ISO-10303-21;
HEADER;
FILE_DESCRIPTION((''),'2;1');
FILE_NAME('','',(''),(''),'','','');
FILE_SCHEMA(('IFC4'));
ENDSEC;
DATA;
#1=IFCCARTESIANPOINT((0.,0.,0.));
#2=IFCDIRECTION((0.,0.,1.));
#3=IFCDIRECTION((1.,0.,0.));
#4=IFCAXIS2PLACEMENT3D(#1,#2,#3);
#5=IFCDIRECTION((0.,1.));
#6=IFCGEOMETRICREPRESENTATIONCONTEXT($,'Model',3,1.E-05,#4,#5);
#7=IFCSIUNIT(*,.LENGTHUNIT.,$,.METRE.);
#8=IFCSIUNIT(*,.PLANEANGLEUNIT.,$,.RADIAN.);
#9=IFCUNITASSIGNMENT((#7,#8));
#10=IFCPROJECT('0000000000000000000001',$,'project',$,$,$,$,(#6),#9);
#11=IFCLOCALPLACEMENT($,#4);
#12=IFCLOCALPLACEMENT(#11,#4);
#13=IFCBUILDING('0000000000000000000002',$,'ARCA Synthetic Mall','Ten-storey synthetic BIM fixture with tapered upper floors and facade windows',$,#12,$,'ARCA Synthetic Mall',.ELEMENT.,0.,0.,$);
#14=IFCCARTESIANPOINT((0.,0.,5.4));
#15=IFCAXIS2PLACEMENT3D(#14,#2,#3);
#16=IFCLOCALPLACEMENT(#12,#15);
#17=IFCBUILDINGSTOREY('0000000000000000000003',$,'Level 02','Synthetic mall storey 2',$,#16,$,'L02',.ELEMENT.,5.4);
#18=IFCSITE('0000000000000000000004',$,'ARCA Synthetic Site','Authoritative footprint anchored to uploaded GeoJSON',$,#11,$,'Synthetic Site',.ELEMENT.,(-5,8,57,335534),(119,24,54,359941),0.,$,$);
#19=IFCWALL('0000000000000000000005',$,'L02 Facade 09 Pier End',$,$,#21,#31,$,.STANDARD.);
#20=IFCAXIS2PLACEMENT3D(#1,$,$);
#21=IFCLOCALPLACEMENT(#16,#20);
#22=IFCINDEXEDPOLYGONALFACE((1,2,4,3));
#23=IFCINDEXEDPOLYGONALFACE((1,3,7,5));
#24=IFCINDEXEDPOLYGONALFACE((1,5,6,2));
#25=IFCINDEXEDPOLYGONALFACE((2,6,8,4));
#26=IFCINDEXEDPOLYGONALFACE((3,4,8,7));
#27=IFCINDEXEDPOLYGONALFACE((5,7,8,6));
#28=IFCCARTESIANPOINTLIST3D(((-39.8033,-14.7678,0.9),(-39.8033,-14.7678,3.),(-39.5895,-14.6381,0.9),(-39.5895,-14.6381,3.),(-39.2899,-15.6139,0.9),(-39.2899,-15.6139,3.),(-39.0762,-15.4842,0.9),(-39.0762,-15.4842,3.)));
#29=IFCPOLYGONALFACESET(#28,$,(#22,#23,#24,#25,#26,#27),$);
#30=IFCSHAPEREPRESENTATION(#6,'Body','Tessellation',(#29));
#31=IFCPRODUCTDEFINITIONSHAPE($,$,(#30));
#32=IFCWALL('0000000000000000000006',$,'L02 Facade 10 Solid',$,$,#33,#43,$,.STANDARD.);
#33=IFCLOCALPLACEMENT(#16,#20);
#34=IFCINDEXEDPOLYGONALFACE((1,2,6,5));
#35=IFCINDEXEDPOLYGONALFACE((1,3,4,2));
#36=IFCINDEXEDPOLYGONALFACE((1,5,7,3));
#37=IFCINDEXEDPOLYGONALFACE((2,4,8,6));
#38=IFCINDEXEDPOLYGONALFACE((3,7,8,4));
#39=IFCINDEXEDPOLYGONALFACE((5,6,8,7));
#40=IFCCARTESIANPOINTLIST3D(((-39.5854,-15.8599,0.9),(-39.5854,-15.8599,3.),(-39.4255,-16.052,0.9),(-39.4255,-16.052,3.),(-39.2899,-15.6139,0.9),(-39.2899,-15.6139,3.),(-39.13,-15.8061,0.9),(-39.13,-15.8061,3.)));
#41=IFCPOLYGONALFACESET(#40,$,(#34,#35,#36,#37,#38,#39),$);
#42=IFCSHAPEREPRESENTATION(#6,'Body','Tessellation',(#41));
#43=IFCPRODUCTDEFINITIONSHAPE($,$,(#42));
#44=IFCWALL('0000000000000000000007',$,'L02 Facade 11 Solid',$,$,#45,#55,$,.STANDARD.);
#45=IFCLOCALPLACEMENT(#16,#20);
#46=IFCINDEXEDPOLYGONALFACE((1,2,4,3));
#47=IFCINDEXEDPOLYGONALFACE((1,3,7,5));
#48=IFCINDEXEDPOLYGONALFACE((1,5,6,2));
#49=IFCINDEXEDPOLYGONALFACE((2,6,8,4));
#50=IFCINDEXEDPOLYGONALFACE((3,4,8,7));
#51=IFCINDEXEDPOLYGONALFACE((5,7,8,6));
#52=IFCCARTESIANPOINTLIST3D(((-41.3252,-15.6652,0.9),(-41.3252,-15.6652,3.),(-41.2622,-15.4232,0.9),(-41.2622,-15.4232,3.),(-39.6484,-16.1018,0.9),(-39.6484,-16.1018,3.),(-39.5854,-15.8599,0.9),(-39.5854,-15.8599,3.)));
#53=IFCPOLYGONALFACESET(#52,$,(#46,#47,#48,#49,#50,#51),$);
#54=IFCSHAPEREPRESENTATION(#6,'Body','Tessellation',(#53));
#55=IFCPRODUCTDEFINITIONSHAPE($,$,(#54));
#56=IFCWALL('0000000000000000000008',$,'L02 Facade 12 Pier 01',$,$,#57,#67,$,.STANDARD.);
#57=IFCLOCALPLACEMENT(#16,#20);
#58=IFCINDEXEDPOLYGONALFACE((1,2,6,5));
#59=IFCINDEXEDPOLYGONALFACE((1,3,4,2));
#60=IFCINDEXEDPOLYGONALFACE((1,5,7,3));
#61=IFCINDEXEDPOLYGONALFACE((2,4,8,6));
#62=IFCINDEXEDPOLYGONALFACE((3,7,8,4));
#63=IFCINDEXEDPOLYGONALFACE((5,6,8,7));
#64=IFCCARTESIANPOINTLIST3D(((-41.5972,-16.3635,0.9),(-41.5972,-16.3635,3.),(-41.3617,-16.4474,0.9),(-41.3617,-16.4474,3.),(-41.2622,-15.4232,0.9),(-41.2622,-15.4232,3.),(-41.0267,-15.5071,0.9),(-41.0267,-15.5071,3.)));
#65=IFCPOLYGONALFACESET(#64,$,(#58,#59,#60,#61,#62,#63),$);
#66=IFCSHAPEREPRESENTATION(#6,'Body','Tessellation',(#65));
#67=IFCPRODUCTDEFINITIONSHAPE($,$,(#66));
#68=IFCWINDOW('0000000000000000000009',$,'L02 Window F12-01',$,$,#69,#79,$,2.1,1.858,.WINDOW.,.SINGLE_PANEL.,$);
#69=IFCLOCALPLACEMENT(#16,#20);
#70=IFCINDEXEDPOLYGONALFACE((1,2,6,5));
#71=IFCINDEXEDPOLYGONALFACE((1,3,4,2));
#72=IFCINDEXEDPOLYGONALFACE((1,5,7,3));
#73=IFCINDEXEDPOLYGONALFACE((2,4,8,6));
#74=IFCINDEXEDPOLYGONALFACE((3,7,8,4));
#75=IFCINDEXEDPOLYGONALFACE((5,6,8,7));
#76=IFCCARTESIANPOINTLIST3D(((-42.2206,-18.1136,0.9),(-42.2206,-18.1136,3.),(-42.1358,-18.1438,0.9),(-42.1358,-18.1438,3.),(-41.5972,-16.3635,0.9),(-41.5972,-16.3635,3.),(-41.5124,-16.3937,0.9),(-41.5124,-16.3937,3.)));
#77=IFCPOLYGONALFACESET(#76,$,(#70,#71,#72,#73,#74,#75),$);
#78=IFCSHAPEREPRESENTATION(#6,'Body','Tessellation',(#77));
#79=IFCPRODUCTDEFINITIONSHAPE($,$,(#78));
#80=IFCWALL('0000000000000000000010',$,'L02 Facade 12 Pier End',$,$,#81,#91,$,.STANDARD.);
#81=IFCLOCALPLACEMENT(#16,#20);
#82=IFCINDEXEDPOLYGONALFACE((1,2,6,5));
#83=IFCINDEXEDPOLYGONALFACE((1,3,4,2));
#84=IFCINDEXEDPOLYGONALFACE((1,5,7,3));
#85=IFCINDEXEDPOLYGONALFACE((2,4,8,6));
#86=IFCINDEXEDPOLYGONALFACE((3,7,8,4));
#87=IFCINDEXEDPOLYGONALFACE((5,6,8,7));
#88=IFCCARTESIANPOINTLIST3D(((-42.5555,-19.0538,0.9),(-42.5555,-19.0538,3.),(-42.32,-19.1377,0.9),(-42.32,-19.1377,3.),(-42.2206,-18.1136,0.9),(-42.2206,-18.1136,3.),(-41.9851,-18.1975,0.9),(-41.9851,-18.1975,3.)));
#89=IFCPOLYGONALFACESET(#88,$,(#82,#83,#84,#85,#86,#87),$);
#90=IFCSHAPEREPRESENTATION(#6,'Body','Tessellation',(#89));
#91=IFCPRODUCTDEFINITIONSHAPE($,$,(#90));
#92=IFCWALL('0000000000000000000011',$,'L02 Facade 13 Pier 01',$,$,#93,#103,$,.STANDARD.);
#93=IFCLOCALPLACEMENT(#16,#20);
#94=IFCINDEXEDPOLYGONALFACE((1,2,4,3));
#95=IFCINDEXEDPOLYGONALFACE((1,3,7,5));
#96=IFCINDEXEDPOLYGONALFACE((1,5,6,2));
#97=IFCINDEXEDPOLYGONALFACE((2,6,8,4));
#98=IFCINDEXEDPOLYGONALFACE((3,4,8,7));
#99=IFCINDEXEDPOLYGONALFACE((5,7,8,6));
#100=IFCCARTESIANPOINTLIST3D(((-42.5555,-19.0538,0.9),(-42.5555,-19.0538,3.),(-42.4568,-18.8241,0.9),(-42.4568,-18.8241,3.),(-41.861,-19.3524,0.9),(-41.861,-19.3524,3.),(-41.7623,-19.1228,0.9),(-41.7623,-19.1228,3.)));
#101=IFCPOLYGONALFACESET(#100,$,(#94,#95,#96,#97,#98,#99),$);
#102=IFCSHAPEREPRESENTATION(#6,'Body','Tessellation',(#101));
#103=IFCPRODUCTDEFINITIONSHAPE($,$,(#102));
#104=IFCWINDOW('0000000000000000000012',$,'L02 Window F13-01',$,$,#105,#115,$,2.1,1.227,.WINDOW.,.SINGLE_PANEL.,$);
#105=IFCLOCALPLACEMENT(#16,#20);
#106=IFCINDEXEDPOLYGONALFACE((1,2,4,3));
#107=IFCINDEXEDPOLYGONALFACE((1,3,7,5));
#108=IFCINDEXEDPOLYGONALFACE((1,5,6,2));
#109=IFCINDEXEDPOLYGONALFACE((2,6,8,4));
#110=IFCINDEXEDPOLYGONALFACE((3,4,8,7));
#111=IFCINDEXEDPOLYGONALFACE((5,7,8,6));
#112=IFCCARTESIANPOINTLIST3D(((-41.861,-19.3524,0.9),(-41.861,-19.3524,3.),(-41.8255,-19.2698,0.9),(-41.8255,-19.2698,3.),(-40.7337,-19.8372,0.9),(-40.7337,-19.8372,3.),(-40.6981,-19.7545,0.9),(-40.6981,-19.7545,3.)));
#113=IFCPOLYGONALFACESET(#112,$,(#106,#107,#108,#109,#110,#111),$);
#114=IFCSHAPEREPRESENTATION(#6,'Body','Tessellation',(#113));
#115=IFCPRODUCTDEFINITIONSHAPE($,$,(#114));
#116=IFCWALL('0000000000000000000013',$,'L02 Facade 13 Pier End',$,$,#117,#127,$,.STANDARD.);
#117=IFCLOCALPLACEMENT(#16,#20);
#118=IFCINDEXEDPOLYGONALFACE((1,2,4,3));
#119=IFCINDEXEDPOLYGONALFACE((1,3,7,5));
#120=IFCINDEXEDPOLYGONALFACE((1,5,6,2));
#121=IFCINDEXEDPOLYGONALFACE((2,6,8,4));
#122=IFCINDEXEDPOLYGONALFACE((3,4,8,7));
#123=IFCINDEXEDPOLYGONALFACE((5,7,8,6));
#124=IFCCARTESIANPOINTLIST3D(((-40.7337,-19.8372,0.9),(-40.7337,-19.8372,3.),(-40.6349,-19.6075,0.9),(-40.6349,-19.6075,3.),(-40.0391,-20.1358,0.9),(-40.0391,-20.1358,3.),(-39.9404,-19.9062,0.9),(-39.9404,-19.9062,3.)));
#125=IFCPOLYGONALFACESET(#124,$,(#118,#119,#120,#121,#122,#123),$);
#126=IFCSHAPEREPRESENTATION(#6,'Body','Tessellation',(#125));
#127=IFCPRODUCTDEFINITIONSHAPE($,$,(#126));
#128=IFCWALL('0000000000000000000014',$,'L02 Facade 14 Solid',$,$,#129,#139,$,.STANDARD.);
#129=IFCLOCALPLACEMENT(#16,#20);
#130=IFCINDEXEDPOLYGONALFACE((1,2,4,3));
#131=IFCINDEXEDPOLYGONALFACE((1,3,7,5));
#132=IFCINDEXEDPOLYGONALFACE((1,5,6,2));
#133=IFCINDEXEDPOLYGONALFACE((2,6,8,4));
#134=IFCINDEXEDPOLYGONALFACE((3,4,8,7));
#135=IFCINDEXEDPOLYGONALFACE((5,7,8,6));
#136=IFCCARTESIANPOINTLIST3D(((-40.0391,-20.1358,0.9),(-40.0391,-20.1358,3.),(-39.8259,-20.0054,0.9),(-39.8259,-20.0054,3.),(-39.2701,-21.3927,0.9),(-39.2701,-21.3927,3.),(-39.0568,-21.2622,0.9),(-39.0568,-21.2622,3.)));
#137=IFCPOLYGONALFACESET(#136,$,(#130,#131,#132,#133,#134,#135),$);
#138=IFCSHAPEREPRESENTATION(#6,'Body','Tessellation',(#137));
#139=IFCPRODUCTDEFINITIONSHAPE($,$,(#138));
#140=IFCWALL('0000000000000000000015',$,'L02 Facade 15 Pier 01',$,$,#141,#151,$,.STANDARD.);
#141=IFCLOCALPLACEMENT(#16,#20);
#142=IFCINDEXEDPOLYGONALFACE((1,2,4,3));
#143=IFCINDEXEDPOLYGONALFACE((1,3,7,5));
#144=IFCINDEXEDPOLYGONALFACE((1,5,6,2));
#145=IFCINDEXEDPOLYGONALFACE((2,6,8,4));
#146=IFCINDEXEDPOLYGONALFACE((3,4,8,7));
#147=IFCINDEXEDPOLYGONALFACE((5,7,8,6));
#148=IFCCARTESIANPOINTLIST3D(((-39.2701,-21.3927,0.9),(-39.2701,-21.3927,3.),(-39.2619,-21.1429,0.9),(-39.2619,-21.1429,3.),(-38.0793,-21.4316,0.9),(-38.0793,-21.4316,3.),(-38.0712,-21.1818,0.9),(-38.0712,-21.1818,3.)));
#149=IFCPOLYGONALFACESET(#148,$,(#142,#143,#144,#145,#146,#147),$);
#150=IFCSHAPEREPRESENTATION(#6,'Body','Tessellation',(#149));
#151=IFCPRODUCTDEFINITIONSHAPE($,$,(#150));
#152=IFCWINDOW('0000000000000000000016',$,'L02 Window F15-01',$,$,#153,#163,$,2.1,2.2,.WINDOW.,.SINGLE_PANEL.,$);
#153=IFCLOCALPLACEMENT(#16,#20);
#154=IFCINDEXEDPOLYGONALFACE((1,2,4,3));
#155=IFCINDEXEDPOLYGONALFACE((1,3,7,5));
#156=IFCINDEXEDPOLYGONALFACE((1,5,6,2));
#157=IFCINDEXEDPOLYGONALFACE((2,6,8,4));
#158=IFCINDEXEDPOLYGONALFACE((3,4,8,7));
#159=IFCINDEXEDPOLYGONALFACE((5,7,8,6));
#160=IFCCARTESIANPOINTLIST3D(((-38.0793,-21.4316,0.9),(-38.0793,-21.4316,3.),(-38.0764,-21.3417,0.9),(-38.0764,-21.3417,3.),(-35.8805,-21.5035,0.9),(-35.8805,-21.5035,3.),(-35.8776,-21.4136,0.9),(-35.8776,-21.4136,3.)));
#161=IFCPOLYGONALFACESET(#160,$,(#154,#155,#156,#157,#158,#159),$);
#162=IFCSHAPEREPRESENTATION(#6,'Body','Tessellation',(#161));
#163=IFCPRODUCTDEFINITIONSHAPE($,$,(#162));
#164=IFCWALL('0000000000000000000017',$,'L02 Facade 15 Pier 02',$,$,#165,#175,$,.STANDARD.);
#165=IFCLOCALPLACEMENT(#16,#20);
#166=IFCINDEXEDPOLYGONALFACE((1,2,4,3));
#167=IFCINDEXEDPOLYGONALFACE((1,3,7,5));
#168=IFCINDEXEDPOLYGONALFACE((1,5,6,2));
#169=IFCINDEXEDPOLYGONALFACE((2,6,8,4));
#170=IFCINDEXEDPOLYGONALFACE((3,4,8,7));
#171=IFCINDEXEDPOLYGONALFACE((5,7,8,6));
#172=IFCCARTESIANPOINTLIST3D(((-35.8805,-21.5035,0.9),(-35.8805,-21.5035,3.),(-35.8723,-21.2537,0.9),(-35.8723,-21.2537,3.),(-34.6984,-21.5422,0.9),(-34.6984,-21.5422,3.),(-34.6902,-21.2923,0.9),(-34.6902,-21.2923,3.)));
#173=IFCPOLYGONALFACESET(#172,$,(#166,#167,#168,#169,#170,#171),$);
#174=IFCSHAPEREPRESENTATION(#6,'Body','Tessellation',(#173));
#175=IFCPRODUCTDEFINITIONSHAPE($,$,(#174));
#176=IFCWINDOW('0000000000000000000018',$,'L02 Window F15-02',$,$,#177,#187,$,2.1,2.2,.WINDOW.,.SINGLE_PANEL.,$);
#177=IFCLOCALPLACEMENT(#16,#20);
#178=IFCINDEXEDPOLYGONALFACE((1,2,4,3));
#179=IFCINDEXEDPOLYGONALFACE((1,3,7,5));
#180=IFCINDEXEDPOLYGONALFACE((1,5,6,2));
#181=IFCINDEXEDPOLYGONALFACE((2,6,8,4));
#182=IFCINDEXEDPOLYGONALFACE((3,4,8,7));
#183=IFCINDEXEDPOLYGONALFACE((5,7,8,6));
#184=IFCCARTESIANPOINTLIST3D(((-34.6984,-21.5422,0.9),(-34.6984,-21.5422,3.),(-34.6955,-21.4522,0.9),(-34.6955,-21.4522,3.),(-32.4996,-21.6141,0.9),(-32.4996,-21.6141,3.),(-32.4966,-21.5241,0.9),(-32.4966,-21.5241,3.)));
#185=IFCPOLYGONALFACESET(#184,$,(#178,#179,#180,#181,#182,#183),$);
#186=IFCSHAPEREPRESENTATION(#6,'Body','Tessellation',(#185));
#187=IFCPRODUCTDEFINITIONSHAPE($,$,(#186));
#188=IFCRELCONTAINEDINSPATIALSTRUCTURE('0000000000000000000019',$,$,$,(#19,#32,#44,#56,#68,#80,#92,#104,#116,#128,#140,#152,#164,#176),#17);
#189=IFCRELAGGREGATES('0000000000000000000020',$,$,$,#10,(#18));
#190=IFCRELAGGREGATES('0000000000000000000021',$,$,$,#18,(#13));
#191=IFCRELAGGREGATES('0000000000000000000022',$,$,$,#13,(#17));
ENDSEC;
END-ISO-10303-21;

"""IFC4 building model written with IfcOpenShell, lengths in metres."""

from ifc_helpers import new_model, si_unit, direction, frame, origin_with_axes, place, context, project, spatial, polyline, outline, extrude, element, save


model = new_model("IFC4")

# Units and contexts
model_context = context("Model", 3, precision=1e-05, world=origin_with_axes(), true_north=direction((0.0, 1.0)))
ifc_project = project(units=[si_unit("LENGTHUNIT", "METRE"), si_unit("PLANEANGLEUNIT", "RADIAN")], contexts=[model_context])

# Site, building, storey
site_placement = place(None, origin_with_axes())
site = spatial("IfcSite", under=ifc_project, at=site_placement, Name="ARCA Synthetic Site", Description="Authoritative footprint anchored to uploaded GeoJSON", LongName="Synthetic Site", CompositionType="ELEMENT", RefLatitude=(-5, 8, 57, 335534), RefLongitude=(119, 24, 54, 359941), RefElevation=0.0)
building_placement = place(site_placement, origin_with_axes())
building = spatial("IfcBuilding", under=site, at=building_placement, Name="ARCA Synthetic Mall", Description="Ten-storey synthetic BIM fixture with tapered upper floors and facade windows", LongName="ARCA Synthetic Mall", CompositionType="ELEMENT", ElevationOfRefHeight=0.0, ElevationOfTerrain=0.0)
storey_placement = place(building_placement, frame((0.0, 0.0, 5.4), z_axis=(0.0, 0.0, 1.0), x_axis=(1.0, 0.0, 0.0)))
storey = spatial("IfcBuildingStorey", under=building, at=storey_placement, Name="Level 02", Description="Synthetic mall storey 2", LongName="L02", CompositionType="ELEMENT", Elevation=5.4)

# Walls
wall_1_placement = place(storey_placement, frame((0.0, 0.0, 0.9), z_axis=(0.0, 0.0, 1.0), x_axis=(1.0, 0.0, 0.0)))
element("IfcWall", 1, at=wall_1_placement, inside=storey, Name="L02 Facade 09 Pier End", PredefinedType="STANDARD", context=model_context, shape_type="SweptSolid", body=[
    extrude(outline(polyline([(-39.8033, -14.7678), (-39.2899, -15.6139), (-39.0762, -15.4842), (-39.5895, -14.6381), (-39.8033, -14.7678)])), origin_with_axes(), (0.0, 0.0, 1.0), 2.1),
])
wall_2_placement = place(storey_placement, frame((0.0, 0.0, 0.9), z_axis=(0.0, 0.0, 1.0), x_axis=(1.0, 0.0, 0.0)))
element("IfcWall", 2, at=wall_2_placement, inside=storey, Name="L02 Facade 10 Solid", PredefinedType="STANDARD", context=model_context, shape_type="SweptSolid", body=[
    extrude(outline(polyline([(-39.2899, -15.6139), (-39.5854, -15.8599), (-39.4255, -16.052), (-39.13, -15.8061), (-39.2899, -15.6139)])), origin_with_axes(), (0.0, 0.0, 1.0), 2.1),
])
wall_3_placement = place(storey_placement, frame((0.0, 0.0, 0.9), z_axis=(0.0, 0.0, 1.0), x_axis=(1.0, 0.0, 0.0)))
element("IfcWall", 3, at=wall_3_placement, inside=storey, Name="L02 Facade 11 Solid", PredefinedType="STANDARD", context=model_context, shape_type="SweptSolid", body=[
    extrude(outline(polyline([(-39.5854, -15.8599), (-41.2622, -15.4232), (-41.3252, -15.6652), (-39.6484, -16.1018), (-39.5854, -15.8599)])), origin_with_axes(), (0.0, 0.0, 1.0), 2.1),
])
wall_4_placement = place(storey_placement, frame((0.0, 0.0, 0.9), z_axis=(0.0, 0.0, 1.0), x_axis=(1.0, 0.0, 0.0)))
element("IfcWall", 4, at=wall_4_placement, inside=storey, Name="L02 Facade 12 Pier 01", PredefinedType="STANDARD", context=model_context, shape_type="SweptSolid", body=[
    extrude(outline(polyline([(-41.2622, -15.4232), (-41.5972, -16.3635), (-41.3617, -16.4474), (-41.0267, -15.5071), (-41.2622, -15.4232)])), origin_with_axes(), (0.0, 0.0, 1.0), 2.1),
])

# Window
window_1_placement = place(storey_placement, frame((0.0, 0.0, 0.9), z_axis=(0.0, 0.0, 1.0), x_axis=(1.0, 0.0, 0.0)))
element("IfcWindow", 5, at=window_1_placement, inside=storey, Name="L02 Window F12-01", OverallHeight=2.1, OverallWidth=1.858, PartitioningType="SINGLE_PANEL", PredefinedType="WINDOW", context=model_context, shape_type="SweptSolid", body=[
    extrude(outline(polyline([(-41.5972, -16.3635), (-42.2206, -18.1136), (-42.1358, -18.1438), (-41.5124, -16.3937), (-41.5972, -16.3635)])), origin_with_axes(), (0.0, 0.0, 1.0), 2.1),
])

# Walls
wall_5_placement = place(storey_placement, frame((0.0, 0.0, 0.9), z_axis=(0.0, 0.0, 1.0), x_axis=(1.0, 0.0, 0.0)))
element("IfcWall", 6, at=wall_5_placement, inside=storey, Name="L02 Facade 12 Pier End", PredefinedType="STANDARD", context=model_context, shape_type="SweptSolid", body=[
    extrude(outline(polyline([(-42.2206, -18.1136), (-42.5555, -19.0538), (-42.32, -19.1377), (-41.9851, -18.1975), (-42.2206, -18.1136)])), origin_with_axes(), (0.0, 0.0, 1.0), 2.1),
])
wall_6_placement = place(storey_placement, frame((0.0, 0.0, 0.9), z_axis=(0.0, 0.0, 1.0), x_axis=(1.0, 0.0, 0.0)))
element("IfcWall", 7, at=wall_6_placement, inside=storey, Name="L02 Facade 13 Pier 01", PredefinedType="STANDARD", context=model_context, shape_type="SweptSolid", body=[
    extrude(outline(polyline([(-42.5555, -19.0538), (-41.861, -19.3524), (-41.7623, -19.1228), (-42.4568, -18.8241), (-42.5555, -19.0538)])), origin_with_axes(), (0.0, 0.0, 1.0), 2.1),
])

# Window
window_2_placement = place(storey_placement, frame((0.0, 0.0, 0.9), z_axis=(0.0, 0.0, 1.0), x_axis=(1.0, 0.0, 0.0)))
element("IfcWindow", 8, at=window_2_placement, inside=storey, Name="L02 Window F13-01", OverallHeight=2.1, OverallWidth=1.227, PartitioningType="SINGLE_PANEL", PredefinedType="WINDOW", context=model_context, shape_type="SweptSolid", body=[
    extrude(outline(polyline([(-41.861, -19.3524), (-40.7337, -19.8372), (-40.6981, -19.7545), (-41.8255, -19.2698), (-41.861, -19.3524)])), origin_with_axes(), (0.0, 0.0, 1.0), 2.1),
])

# Walls
wall_7_placement = place(storey_placement, frame((0.0, 0.0, 0.9), z_axis=(0.0, 0.0, 1.0), x_axis=(1.0, 0.0, 0.0)))
element("IfcWall", 9, at=wall_7_placement, inside=storey, Name="L02 Facade 13 Pier End", PredefinedType="STANDARD", context=model_context, shape_type="SweptSolid", body=[
    extrude(outline(polyline([(-40.7337, -19.8372), (-40.0391, -20.1358), (-39.9404, -19.9062), (-40.6349, -19.6075), (-40.7337, -19.8372)])), origin_with_axes(), (0.0, 0.0, 1.0), 2.1),
])
wall_8_placement = place(storey_placement, frame((0.0, 0.0, 0.9), z_axis=(0.0, 0.0, 1.0), x_axis=(1.0, 0.0, 0.0)))
element("IfcWall", 10, at=wall_8_placement, inside=storey, Name="L02 Facade 14 Solid", PredefinedType="STANDARD", context=model_context, shape_type="SweptSolid", body=[
    extrude(outline(polyline([(-40.0391, -20.1358), (-39.2701, -21.3927), (-39.0568, -21.2622), (-39.8259, -20.0054), (-40.0391, -20.1358)])), origin_with_axes(), (0.0, 0.0, 1.0), 2.1),
])
wall_9_placement = place(storey_placement, frame((0.0, 0.0, 0.9), z_axis=(0.0, 0.0, 1.0), x_axis=(1.0, 0.0, 0.0)))
element("IfcWall", 11, at=wall_9_placement, inside=storey, Name="L02 Facade 15 Pier 01", PredefinedType="STANDARD", context=model_context, shape_type="SweptSolid", body=[
    extrude(outline(polyline([(-39.2701, -21.3927), (-38.0793, -21.4316), (-38.0712, -21.1818), (-39.2619, -21.1429), (-39.2701, -21.3927)])), origin_with_axes(), (0.0, 0.0, 1.0), 2.1),
])

# Window
window_3_placement = place(storey_placement, frame((0.0, 0.0, 0.9), z_axis=(0.0, 0.0, 1.0), x_axis=(1.0, 0.0, 0.0)))
element("IfcWindow", 12, at=window_3_placement, inside=storey, Name="L02 Window F15-01", OverallHeight=2.1, OverallWidth=2.2, PartitioningType="SINGLE_PANEL", PredefinedType="WINDOW", context=model_context, shape_type="SweptSolid", body=[
    extrude(outline(polyline([(-38.0793, -21.4316), (-35.8805, -21.5035), (-35.8776, -21.4136), (-38.0764, -21.3417), (-38.0793, -21.4316)])), origin_with_axes(), (0.0, 0.0, 1.0), 2.1),
])

# Wall
wall_10_placement = place(storey_placement, frame((0.0, 0.0, 0.9), z_axis=(0.0, 0.0, 1.0), x_axis=(1.0, 0.0, 0.0)))
element("IfcWall", 13, at=wall_10_placement, inside=storey, Name="L02 Facade 15 Pier 02", PredefinedType="STANDARD", context=model_context, shape_type="SweptSolid", body=[
    extrude(outline(polyline([(-35.8805, -21.5035), (-34.6984, -21.5422), (-34.6902, -21.2923), (-35.8723, -21.2537), (-35.8805, -21.5035)])), origin_with_axes(), (0.0, 0.0, 1.0), 2.1),
])

# Window
window_4_placement = place(storey_placement, frame((0.0, 0.0, 0.9), z_axis=(0.0, 0.0, 1.0), x_axis=(1.0, 0.0, 0.0)))
element("IfcWindow", 14, at=window_4_placement, inside=storey, Name="L02 Window F15-02", OverallHeight=2.1, OverallWidth=2.2, PartitioningType="SINGLE_PANEL", PredefinedType="WINDOW", context=model_context, shape_type="SweptSolid", body=[
    extrude(outline(polyline([(-34.6984, -21.5422), (-32.4996, -21.6141), (-32.4966, -21.5241), (-34.6955, -21.4522), (-34.6984, -21.5422)])), origin_with_axes(), (0.0, 0.0, 1.0), 2.1),
])

save(model, "model.ifc")
